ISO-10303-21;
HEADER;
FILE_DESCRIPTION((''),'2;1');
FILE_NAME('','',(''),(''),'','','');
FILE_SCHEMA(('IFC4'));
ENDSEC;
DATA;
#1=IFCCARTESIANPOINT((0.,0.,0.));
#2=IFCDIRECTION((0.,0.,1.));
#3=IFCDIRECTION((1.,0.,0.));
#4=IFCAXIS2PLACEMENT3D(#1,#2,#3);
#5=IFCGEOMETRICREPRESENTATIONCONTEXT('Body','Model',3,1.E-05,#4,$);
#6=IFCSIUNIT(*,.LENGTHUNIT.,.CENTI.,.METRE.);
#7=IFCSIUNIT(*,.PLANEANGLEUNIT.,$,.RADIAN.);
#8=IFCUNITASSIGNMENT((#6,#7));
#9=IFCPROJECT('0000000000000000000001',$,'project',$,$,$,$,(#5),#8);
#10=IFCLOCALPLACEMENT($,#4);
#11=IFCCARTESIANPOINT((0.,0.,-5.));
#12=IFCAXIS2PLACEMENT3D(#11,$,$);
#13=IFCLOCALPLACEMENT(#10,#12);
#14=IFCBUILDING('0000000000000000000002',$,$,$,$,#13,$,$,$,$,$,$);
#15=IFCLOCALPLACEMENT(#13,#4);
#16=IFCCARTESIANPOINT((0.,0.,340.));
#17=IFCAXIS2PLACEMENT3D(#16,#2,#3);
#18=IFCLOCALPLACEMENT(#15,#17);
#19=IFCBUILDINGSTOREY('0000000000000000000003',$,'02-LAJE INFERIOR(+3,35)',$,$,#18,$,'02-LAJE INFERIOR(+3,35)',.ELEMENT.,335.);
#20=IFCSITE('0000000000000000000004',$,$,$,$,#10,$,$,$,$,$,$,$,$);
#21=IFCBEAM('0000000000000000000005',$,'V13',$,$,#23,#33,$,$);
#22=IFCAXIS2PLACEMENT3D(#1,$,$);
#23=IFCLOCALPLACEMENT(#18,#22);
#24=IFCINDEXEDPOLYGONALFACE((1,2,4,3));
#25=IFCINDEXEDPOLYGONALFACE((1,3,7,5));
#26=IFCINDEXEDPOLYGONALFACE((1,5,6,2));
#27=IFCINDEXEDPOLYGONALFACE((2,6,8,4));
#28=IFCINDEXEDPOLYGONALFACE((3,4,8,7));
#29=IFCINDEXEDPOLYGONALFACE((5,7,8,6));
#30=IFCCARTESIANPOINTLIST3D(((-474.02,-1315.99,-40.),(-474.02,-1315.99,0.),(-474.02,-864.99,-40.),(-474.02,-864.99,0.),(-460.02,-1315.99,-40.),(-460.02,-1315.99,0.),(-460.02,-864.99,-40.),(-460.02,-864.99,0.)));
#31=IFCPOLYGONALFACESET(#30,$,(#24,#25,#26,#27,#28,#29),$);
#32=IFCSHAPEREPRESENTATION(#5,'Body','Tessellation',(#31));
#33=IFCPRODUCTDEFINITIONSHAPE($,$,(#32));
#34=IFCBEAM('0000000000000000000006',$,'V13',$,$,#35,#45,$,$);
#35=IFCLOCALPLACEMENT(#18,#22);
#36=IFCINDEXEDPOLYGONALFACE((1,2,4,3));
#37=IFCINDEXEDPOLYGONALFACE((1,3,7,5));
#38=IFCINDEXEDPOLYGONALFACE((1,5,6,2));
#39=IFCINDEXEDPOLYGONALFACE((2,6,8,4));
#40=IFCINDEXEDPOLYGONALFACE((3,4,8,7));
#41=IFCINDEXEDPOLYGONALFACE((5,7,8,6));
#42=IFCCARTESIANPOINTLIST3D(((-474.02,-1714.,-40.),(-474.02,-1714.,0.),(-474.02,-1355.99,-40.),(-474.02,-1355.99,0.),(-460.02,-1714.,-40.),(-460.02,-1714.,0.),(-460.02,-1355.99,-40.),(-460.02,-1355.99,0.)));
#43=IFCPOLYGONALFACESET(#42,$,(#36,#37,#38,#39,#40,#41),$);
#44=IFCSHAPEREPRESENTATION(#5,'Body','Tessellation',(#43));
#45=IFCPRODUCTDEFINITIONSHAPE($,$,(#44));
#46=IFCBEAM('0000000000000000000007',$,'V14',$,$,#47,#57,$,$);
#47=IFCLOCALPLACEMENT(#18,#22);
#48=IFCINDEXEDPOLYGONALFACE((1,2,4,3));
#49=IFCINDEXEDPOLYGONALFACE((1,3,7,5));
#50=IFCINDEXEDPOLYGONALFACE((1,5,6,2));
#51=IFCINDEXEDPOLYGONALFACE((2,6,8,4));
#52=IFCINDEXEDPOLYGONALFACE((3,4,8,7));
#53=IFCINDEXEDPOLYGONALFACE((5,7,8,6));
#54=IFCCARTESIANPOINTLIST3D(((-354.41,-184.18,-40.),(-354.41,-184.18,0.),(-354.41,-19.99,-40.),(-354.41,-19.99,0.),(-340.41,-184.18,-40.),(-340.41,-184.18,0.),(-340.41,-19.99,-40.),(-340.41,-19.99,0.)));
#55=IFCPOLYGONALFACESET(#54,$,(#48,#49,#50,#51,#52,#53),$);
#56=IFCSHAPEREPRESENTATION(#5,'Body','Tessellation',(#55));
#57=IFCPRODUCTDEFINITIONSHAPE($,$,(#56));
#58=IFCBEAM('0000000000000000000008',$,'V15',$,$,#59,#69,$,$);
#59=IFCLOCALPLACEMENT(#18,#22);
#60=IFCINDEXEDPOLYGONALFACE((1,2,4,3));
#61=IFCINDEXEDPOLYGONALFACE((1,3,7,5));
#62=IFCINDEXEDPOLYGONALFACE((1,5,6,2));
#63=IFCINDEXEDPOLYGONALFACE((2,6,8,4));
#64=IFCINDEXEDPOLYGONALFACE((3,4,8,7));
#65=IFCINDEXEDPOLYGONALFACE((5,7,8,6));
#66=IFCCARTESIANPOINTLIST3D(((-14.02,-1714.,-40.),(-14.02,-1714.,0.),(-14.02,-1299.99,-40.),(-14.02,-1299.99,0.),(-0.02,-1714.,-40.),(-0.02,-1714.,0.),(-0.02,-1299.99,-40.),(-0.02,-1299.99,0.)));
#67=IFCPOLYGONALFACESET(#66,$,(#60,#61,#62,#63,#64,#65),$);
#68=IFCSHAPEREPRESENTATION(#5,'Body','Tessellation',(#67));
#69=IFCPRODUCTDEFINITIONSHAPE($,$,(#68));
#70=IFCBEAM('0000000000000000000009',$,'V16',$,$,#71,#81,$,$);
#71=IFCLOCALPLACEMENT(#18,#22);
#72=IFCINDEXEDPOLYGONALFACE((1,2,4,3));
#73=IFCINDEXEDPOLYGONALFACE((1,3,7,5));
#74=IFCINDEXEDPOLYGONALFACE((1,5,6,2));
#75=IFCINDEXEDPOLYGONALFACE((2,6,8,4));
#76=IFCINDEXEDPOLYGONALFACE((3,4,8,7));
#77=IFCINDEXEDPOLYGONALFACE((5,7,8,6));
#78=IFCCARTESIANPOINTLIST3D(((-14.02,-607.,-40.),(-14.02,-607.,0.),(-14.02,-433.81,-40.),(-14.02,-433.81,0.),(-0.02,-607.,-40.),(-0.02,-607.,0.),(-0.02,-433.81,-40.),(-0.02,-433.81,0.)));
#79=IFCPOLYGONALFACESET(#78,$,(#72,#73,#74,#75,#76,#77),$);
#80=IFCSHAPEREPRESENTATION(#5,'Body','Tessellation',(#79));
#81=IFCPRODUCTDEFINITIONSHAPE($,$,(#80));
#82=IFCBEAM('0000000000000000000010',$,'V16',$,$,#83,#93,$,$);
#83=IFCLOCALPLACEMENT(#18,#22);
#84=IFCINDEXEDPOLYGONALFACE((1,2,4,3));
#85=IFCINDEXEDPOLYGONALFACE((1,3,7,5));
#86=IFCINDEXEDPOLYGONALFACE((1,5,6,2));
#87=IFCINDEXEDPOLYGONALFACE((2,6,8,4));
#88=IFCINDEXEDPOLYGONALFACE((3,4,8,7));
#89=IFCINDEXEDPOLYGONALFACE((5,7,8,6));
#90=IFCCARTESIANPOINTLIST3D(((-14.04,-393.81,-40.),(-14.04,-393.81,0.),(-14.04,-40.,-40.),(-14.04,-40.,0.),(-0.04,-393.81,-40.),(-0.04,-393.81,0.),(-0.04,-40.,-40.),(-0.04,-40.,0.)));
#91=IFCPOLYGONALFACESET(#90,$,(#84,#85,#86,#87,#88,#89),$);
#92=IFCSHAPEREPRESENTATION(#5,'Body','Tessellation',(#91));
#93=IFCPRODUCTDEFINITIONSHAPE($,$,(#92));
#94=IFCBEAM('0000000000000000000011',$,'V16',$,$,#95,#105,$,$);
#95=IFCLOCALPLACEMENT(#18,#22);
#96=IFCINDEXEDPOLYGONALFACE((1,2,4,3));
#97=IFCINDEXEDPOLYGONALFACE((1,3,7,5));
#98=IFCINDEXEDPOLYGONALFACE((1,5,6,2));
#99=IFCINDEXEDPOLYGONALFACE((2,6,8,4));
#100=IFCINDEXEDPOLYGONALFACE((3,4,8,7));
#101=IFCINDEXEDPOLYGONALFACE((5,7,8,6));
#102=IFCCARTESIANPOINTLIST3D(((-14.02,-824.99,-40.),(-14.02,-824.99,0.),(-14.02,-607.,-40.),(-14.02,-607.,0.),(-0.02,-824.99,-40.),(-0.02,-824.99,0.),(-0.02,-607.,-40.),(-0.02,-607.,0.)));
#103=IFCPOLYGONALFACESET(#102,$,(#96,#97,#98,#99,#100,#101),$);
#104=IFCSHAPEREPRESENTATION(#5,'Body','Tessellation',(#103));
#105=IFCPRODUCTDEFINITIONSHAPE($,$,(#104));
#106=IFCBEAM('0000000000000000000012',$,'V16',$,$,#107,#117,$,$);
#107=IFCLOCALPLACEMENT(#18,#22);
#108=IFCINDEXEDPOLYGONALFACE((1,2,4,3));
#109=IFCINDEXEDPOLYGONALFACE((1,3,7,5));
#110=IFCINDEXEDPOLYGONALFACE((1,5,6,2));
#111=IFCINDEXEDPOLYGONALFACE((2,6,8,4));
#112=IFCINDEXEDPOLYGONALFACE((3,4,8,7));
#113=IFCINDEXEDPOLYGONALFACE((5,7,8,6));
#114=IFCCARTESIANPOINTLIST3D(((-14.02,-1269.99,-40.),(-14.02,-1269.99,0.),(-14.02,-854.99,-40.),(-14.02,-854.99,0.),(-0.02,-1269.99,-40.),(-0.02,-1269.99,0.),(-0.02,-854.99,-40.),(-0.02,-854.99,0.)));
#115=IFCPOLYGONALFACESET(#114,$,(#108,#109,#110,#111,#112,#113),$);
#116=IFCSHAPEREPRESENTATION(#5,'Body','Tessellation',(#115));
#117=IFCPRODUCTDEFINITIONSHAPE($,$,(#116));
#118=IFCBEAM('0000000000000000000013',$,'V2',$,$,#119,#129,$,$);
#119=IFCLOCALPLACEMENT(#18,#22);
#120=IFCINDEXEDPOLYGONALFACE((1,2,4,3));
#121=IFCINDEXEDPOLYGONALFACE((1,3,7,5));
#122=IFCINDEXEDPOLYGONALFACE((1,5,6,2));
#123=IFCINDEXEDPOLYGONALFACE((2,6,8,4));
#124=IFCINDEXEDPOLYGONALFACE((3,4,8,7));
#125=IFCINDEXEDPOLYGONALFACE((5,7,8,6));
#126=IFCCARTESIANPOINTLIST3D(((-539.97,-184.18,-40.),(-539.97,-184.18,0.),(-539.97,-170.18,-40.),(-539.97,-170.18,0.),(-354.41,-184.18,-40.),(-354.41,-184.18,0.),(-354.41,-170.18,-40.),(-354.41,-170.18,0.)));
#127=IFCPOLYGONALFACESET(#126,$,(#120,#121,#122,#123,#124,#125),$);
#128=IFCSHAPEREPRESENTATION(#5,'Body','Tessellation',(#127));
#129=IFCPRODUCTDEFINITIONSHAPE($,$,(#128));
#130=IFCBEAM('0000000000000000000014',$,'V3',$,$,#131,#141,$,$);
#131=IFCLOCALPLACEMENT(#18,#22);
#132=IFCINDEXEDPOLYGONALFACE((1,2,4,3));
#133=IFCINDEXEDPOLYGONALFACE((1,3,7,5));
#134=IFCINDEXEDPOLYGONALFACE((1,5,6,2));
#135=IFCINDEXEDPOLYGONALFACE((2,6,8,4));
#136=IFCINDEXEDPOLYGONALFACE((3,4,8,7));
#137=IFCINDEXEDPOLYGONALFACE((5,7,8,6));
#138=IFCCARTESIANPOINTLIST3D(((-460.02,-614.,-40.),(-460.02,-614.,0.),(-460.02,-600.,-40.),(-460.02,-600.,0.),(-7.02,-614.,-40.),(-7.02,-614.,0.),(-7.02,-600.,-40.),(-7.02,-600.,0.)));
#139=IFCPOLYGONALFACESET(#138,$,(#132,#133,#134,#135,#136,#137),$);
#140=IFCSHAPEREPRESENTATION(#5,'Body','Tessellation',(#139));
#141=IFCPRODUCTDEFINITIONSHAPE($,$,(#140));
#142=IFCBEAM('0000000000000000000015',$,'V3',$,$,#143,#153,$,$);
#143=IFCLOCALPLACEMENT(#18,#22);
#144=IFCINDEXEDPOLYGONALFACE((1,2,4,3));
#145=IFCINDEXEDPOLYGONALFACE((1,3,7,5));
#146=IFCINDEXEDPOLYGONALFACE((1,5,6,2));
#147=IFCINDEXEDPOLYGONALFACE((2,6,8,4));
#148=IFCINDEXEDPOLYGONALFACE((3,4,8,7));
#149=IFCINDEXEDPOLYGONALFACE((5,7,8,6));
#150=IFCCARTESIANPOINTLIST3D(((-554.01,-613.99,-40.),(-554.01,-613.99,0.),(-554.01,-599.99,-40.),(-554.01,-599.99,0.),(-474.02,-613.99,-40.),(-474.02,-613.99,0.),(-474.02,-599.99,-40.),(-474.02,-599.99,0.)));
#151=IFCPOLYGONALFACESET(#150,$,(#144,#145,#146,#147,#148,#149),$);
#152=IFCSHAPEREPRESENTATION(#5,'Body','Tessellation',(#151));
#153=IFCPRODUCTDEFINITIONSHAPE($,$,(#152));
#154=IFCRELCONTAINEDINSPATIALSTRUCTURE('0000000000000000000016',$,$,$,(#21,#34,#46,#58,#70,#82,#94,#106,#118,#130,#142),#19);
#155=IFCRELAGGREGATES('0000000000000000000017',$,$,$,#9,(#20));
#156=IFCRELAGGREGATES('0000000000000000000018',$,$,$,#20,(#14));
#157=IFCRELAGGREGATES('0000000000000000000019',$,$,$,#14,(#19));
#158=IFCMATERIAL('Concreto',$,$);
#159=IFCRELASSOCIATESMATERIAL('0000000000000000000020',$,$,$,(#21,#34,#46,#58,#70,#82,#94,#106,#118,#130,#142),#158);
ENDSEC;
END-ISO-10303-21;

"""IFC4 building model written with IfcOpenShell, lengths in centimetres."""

from ifc_helpers import new_model, si_unit, frame, origin_with_axes, origin_2d_with_axis, place, context, project, spatial, rectangle, extrude, material, element, save


model = new_model("IFC4")

# Units and contexts
model_context = context("Model", 3, precision=1e-05, world=origin_with_axes(), identifier="Body")
ifc_project = project(units=[si_unit("LENGTHUNIT", "METRE", prefix="CENTI"), si_unit("PLANEANGLEUNIT", "RADIAN")], contexts=[model_context])

# Site, building, storey
site_placement = place(None, origin_with_axes())
site = spatial("IfcSite", under=ifc_project, at=site_placement)
building_placement = place(site_placement, frame((0.0, 0.0, -5.0)))
building = spatial("IfcBuilding", under=site, at=building_placement)
placement = place(building_placement, origin_with_axes())
storey_placement = place(placement, frame((0.0, 0.0, 340.0), z_axis=(0.0, 0.0, 1.0), x_axis=(1.0, 0.0, 0.0)))
storey = spatial("IfcBuildingStorey", under=building, at=storey_placement, Name="02-LAJE INFERIOR(+3,35)", LongName="02-LAJE INFERIOR(+3,35)", CompositionType="ELEMENT", Elevation=335.0)

# Shared definitions
ifc_material = material(Name="Concreto")

# Beams
beam_1_placement = place(storey_placement, frame((-467.02, -1090.49, 0.0), z_axis=(0.0, 0.0, 1.0), x_axis=(1.0, 0.0, 0.0)))
element("IfcBeam", 1, at=beam_1_placement, inside=storey, material=ifc_material, Name="V13", context=model_context, shape_type="SolidModel", body=[
    extrude(rectangle(XDim=14.0, YDim=40.0, at=origin_2d_with_axis()), frame((0.0, -225.5, -20.0), z_axis=(0.0, 1.0, 0.0), x_axis=(1.0, 0.0, 0.0)), (0.0, 0.0, 1.0), 451.0),
])
beam_2_placement = place(storey_placement, frame((-467.02, -1534.99, 0.0), z_axis=(0.0, 0.0, 1.0), x_axis=(1.0, 0.0, 0.0)))
element("IfcBeam", 2, at=beam_2_placement, inside=storey, material=ifc_material, Name="V13", context=model_context, shape_type="SolidModel", body=[
    extrude(rectangle(XDim=14.0, YDim=40.0, at=origin_2d_with_axis()), frame((0.0, -179.0, -20.0), z_axis=(0.0, 1.0, 0.0), x_axis=(1.0, 0.0, 0.0)), (0.0, 0.0, 1.0), 358.01),
])
beam_3_placement = place(storey_placement, frame((-347.41, -102.08, 0.0), z_axis=(0.0, 0.0, 1.0), x_axis=(1.0, 0.0, 0.0)))
element("IfcBeam", 3, at=beam_3_placement, inside=storey, material=ifc_material, Name="V14", context=model_context, shape_type="SolidModel", body=[
    extrude(rectangle(XDim=14.0, YDim=40.0, at=origin_2d_with_axis()), frame((0.0, -82.09, -20.0), z_axis=(0.0, 1.0, 0.0), x_axis=(-1.0, 0.0, 0.0)), (0.0, 0.0, 1.0), 164.19),
])
beam_4_placement = place(storey_placement, frame((-7.02, -1506.99, 0.0), z_axis=(0.0, 0.0, 1.0), x_axis=(1.0, 0.0, 0.0)))
element("IfcBeam", 4, at=beam_4_placement, inside=storey, material=ifc_material, Name="V15", context=model_context, shape_type="SolidModel", body=[
    extrude(rectangle(XDim=14.0, YDim=40.0, at=origin_2d_with_axis()), frame((0.0, -207.0, -20.0), z_axis=(0.0, 1.0, 0.0), x_axis=(1.0, 0.0, 0.0)), (0.0, 0.0, 1.0), 414.01),
])
beam_5_placement = place(storey_placement, frame((-7.02, -520.4, 0.0), z_axis=(0.0, 0.0, 1.0), x_axis=(1.0, 0.0, 0.0)))
element("IfcBeam", 5, at=beam_5_placement, inside=storey, material=ifc_material, Name="V16", context=model_context, shape_type="SolidModel", body=[
    extrude(rectangle(XDim=14.0, YDim=40.0, at=origin_2d_with_axis()), frame((0.0, -86.59, -20.0), z_axis=(0.0, 1.0, 0.0), x_axis=(1.0, 0.0, 0.0)), (0.0, 0.0, 1.0), 173.19),
])
beam_6_placement = place(storey_placement, frame((-7.04, -216.91, 0.0), z_axis=(0.0, 0.0, 1.0), x_axis=(1.0, 0.0, 0.0)))
element("IfcBeam", 6, at=beam_6_placement, inside=storey, material=ifc_material, Name="V16", context=model_context, shape_type="SolidModel", body=[
    extrude(rectangle(XDim=14.0, YDim=40.0, at=origin_2d_with_axis()), frame((0.0, -176.91, -20.0), z_axis=(0.0, 1.0, 0.0), x_axis=(1.0, 0.0, 0.0)), (0.0, 0.0, 1.0), 353.81),
])
beam_7_placement = place(storey_placement, frame((-7.02, -716.0, 0.0), z_axis=(0.0, 0.0, 1.0), x_axis=(1.0, 0.0, 0.0)))
element("IfcBeam", 7, at=beam_7_placement, inside=storey, material=ifc_material, Name="V16", context=model_context, shape_type="SolidModel", body=[
    extrude(rectangle(XDim=14.0, YDim=40.0, at=origin_2d_with_axis()), frame((0.0, -109.0, -20.0), z_axis=(0.0, 1.0, 0.0), x_axis=(1.0, 0.0, 0.0)), (0.0, 0.0, 1.0), 217.99),
])
beam_8_placement = place(storey_placement, frame((-7.02, -1062.49, 0.0), z_axis=(0.0, 0.0, 1.0), x_axis=(1.0, 0.0, 0.0)))
element("IfcBeam", 8, at=beam_8_placement, inside=storey, material=ifc_material, Name="V16", context=model_context, shape_type="SolidModel", body=[
    extrude(rectangle(XDim=14.0, YDim=40.0, at=origin_2d_with_axis()), frame((0.0, -207.5, -20.0), z_axis=(0.0, 1.0, 0.0), x_axis=(1.0, 0.0, 0.0)), (0.0, 0.0, 1.0), 415.0),
])
beam_9_placement = place(storey_placement, frame((-447.19, -177.18, 0.0), z_axis=(0.0, 0.0, 1.0), x_axis=(1.0, 0.0, 0.0)))
element("IfcBeam", 9, at=beam_9_placement, inside=storey, material=ifc_material, Name="V2", context=model_context, shape_type="SolidModel", body=[
    extrude(rectangle(XDim=14.0, YDim=40.0, at=origin_2d_with_axis()), frame((-92.78, 0.0, -20.0), z_axis=(1.0, 0.0, 0.0), x_axis=(0.0, -1.0, 0.0)), (0.0, 0.0, 1.0), 185.56),
])
beam_10_placement = place(storey_placement, frame((-233.52, -607.0, 0.0), z_axis=(0.0, 0.0, 1.0), x_axis=(1.0, 0.0, 0.0)))
element("IfcBeam", 10, at=beam_10_placement, inside=storey, material=ifc_material, Name="V3", context=model_context, shape_type="SolidModel", body=[
    extrude(rectangle(XDim=14.0, YDim=40.0, at=origin_2d_with_axis()), frame((-226.5, 0.0, -20.0), z_axis=(1.0, 0.0, 0.0), x_axis=(0.0, -1.0, 0.0)), (0.0, 0.0, 1.0), 453.0),
])
beam_11_placement = place(storey_placement, frame((-514.01, -606.99, 0.0), z_axis=(0.0, 0.0, 1.0), x_axis=(1.0, 0.0, 0.0)))
element("IfcBeam", 11, at=beam_11_placement, inside=storey, material=ifc_material, Name="V3", context=model_context, shape_type="SolidModel", body=[
    extrude(rectangle(XDim=14.0, YDim=40.0, at=origin_2d_with_axis()), frame((-39.99, 0.0, -20.0), z_axis=(1.0, 0.0, 0.0), x_axis=(0.0, -1.0, 0.0)), (0.0, 0.0, 1.0), 79.99),
])

save(model, "model.ifc")
